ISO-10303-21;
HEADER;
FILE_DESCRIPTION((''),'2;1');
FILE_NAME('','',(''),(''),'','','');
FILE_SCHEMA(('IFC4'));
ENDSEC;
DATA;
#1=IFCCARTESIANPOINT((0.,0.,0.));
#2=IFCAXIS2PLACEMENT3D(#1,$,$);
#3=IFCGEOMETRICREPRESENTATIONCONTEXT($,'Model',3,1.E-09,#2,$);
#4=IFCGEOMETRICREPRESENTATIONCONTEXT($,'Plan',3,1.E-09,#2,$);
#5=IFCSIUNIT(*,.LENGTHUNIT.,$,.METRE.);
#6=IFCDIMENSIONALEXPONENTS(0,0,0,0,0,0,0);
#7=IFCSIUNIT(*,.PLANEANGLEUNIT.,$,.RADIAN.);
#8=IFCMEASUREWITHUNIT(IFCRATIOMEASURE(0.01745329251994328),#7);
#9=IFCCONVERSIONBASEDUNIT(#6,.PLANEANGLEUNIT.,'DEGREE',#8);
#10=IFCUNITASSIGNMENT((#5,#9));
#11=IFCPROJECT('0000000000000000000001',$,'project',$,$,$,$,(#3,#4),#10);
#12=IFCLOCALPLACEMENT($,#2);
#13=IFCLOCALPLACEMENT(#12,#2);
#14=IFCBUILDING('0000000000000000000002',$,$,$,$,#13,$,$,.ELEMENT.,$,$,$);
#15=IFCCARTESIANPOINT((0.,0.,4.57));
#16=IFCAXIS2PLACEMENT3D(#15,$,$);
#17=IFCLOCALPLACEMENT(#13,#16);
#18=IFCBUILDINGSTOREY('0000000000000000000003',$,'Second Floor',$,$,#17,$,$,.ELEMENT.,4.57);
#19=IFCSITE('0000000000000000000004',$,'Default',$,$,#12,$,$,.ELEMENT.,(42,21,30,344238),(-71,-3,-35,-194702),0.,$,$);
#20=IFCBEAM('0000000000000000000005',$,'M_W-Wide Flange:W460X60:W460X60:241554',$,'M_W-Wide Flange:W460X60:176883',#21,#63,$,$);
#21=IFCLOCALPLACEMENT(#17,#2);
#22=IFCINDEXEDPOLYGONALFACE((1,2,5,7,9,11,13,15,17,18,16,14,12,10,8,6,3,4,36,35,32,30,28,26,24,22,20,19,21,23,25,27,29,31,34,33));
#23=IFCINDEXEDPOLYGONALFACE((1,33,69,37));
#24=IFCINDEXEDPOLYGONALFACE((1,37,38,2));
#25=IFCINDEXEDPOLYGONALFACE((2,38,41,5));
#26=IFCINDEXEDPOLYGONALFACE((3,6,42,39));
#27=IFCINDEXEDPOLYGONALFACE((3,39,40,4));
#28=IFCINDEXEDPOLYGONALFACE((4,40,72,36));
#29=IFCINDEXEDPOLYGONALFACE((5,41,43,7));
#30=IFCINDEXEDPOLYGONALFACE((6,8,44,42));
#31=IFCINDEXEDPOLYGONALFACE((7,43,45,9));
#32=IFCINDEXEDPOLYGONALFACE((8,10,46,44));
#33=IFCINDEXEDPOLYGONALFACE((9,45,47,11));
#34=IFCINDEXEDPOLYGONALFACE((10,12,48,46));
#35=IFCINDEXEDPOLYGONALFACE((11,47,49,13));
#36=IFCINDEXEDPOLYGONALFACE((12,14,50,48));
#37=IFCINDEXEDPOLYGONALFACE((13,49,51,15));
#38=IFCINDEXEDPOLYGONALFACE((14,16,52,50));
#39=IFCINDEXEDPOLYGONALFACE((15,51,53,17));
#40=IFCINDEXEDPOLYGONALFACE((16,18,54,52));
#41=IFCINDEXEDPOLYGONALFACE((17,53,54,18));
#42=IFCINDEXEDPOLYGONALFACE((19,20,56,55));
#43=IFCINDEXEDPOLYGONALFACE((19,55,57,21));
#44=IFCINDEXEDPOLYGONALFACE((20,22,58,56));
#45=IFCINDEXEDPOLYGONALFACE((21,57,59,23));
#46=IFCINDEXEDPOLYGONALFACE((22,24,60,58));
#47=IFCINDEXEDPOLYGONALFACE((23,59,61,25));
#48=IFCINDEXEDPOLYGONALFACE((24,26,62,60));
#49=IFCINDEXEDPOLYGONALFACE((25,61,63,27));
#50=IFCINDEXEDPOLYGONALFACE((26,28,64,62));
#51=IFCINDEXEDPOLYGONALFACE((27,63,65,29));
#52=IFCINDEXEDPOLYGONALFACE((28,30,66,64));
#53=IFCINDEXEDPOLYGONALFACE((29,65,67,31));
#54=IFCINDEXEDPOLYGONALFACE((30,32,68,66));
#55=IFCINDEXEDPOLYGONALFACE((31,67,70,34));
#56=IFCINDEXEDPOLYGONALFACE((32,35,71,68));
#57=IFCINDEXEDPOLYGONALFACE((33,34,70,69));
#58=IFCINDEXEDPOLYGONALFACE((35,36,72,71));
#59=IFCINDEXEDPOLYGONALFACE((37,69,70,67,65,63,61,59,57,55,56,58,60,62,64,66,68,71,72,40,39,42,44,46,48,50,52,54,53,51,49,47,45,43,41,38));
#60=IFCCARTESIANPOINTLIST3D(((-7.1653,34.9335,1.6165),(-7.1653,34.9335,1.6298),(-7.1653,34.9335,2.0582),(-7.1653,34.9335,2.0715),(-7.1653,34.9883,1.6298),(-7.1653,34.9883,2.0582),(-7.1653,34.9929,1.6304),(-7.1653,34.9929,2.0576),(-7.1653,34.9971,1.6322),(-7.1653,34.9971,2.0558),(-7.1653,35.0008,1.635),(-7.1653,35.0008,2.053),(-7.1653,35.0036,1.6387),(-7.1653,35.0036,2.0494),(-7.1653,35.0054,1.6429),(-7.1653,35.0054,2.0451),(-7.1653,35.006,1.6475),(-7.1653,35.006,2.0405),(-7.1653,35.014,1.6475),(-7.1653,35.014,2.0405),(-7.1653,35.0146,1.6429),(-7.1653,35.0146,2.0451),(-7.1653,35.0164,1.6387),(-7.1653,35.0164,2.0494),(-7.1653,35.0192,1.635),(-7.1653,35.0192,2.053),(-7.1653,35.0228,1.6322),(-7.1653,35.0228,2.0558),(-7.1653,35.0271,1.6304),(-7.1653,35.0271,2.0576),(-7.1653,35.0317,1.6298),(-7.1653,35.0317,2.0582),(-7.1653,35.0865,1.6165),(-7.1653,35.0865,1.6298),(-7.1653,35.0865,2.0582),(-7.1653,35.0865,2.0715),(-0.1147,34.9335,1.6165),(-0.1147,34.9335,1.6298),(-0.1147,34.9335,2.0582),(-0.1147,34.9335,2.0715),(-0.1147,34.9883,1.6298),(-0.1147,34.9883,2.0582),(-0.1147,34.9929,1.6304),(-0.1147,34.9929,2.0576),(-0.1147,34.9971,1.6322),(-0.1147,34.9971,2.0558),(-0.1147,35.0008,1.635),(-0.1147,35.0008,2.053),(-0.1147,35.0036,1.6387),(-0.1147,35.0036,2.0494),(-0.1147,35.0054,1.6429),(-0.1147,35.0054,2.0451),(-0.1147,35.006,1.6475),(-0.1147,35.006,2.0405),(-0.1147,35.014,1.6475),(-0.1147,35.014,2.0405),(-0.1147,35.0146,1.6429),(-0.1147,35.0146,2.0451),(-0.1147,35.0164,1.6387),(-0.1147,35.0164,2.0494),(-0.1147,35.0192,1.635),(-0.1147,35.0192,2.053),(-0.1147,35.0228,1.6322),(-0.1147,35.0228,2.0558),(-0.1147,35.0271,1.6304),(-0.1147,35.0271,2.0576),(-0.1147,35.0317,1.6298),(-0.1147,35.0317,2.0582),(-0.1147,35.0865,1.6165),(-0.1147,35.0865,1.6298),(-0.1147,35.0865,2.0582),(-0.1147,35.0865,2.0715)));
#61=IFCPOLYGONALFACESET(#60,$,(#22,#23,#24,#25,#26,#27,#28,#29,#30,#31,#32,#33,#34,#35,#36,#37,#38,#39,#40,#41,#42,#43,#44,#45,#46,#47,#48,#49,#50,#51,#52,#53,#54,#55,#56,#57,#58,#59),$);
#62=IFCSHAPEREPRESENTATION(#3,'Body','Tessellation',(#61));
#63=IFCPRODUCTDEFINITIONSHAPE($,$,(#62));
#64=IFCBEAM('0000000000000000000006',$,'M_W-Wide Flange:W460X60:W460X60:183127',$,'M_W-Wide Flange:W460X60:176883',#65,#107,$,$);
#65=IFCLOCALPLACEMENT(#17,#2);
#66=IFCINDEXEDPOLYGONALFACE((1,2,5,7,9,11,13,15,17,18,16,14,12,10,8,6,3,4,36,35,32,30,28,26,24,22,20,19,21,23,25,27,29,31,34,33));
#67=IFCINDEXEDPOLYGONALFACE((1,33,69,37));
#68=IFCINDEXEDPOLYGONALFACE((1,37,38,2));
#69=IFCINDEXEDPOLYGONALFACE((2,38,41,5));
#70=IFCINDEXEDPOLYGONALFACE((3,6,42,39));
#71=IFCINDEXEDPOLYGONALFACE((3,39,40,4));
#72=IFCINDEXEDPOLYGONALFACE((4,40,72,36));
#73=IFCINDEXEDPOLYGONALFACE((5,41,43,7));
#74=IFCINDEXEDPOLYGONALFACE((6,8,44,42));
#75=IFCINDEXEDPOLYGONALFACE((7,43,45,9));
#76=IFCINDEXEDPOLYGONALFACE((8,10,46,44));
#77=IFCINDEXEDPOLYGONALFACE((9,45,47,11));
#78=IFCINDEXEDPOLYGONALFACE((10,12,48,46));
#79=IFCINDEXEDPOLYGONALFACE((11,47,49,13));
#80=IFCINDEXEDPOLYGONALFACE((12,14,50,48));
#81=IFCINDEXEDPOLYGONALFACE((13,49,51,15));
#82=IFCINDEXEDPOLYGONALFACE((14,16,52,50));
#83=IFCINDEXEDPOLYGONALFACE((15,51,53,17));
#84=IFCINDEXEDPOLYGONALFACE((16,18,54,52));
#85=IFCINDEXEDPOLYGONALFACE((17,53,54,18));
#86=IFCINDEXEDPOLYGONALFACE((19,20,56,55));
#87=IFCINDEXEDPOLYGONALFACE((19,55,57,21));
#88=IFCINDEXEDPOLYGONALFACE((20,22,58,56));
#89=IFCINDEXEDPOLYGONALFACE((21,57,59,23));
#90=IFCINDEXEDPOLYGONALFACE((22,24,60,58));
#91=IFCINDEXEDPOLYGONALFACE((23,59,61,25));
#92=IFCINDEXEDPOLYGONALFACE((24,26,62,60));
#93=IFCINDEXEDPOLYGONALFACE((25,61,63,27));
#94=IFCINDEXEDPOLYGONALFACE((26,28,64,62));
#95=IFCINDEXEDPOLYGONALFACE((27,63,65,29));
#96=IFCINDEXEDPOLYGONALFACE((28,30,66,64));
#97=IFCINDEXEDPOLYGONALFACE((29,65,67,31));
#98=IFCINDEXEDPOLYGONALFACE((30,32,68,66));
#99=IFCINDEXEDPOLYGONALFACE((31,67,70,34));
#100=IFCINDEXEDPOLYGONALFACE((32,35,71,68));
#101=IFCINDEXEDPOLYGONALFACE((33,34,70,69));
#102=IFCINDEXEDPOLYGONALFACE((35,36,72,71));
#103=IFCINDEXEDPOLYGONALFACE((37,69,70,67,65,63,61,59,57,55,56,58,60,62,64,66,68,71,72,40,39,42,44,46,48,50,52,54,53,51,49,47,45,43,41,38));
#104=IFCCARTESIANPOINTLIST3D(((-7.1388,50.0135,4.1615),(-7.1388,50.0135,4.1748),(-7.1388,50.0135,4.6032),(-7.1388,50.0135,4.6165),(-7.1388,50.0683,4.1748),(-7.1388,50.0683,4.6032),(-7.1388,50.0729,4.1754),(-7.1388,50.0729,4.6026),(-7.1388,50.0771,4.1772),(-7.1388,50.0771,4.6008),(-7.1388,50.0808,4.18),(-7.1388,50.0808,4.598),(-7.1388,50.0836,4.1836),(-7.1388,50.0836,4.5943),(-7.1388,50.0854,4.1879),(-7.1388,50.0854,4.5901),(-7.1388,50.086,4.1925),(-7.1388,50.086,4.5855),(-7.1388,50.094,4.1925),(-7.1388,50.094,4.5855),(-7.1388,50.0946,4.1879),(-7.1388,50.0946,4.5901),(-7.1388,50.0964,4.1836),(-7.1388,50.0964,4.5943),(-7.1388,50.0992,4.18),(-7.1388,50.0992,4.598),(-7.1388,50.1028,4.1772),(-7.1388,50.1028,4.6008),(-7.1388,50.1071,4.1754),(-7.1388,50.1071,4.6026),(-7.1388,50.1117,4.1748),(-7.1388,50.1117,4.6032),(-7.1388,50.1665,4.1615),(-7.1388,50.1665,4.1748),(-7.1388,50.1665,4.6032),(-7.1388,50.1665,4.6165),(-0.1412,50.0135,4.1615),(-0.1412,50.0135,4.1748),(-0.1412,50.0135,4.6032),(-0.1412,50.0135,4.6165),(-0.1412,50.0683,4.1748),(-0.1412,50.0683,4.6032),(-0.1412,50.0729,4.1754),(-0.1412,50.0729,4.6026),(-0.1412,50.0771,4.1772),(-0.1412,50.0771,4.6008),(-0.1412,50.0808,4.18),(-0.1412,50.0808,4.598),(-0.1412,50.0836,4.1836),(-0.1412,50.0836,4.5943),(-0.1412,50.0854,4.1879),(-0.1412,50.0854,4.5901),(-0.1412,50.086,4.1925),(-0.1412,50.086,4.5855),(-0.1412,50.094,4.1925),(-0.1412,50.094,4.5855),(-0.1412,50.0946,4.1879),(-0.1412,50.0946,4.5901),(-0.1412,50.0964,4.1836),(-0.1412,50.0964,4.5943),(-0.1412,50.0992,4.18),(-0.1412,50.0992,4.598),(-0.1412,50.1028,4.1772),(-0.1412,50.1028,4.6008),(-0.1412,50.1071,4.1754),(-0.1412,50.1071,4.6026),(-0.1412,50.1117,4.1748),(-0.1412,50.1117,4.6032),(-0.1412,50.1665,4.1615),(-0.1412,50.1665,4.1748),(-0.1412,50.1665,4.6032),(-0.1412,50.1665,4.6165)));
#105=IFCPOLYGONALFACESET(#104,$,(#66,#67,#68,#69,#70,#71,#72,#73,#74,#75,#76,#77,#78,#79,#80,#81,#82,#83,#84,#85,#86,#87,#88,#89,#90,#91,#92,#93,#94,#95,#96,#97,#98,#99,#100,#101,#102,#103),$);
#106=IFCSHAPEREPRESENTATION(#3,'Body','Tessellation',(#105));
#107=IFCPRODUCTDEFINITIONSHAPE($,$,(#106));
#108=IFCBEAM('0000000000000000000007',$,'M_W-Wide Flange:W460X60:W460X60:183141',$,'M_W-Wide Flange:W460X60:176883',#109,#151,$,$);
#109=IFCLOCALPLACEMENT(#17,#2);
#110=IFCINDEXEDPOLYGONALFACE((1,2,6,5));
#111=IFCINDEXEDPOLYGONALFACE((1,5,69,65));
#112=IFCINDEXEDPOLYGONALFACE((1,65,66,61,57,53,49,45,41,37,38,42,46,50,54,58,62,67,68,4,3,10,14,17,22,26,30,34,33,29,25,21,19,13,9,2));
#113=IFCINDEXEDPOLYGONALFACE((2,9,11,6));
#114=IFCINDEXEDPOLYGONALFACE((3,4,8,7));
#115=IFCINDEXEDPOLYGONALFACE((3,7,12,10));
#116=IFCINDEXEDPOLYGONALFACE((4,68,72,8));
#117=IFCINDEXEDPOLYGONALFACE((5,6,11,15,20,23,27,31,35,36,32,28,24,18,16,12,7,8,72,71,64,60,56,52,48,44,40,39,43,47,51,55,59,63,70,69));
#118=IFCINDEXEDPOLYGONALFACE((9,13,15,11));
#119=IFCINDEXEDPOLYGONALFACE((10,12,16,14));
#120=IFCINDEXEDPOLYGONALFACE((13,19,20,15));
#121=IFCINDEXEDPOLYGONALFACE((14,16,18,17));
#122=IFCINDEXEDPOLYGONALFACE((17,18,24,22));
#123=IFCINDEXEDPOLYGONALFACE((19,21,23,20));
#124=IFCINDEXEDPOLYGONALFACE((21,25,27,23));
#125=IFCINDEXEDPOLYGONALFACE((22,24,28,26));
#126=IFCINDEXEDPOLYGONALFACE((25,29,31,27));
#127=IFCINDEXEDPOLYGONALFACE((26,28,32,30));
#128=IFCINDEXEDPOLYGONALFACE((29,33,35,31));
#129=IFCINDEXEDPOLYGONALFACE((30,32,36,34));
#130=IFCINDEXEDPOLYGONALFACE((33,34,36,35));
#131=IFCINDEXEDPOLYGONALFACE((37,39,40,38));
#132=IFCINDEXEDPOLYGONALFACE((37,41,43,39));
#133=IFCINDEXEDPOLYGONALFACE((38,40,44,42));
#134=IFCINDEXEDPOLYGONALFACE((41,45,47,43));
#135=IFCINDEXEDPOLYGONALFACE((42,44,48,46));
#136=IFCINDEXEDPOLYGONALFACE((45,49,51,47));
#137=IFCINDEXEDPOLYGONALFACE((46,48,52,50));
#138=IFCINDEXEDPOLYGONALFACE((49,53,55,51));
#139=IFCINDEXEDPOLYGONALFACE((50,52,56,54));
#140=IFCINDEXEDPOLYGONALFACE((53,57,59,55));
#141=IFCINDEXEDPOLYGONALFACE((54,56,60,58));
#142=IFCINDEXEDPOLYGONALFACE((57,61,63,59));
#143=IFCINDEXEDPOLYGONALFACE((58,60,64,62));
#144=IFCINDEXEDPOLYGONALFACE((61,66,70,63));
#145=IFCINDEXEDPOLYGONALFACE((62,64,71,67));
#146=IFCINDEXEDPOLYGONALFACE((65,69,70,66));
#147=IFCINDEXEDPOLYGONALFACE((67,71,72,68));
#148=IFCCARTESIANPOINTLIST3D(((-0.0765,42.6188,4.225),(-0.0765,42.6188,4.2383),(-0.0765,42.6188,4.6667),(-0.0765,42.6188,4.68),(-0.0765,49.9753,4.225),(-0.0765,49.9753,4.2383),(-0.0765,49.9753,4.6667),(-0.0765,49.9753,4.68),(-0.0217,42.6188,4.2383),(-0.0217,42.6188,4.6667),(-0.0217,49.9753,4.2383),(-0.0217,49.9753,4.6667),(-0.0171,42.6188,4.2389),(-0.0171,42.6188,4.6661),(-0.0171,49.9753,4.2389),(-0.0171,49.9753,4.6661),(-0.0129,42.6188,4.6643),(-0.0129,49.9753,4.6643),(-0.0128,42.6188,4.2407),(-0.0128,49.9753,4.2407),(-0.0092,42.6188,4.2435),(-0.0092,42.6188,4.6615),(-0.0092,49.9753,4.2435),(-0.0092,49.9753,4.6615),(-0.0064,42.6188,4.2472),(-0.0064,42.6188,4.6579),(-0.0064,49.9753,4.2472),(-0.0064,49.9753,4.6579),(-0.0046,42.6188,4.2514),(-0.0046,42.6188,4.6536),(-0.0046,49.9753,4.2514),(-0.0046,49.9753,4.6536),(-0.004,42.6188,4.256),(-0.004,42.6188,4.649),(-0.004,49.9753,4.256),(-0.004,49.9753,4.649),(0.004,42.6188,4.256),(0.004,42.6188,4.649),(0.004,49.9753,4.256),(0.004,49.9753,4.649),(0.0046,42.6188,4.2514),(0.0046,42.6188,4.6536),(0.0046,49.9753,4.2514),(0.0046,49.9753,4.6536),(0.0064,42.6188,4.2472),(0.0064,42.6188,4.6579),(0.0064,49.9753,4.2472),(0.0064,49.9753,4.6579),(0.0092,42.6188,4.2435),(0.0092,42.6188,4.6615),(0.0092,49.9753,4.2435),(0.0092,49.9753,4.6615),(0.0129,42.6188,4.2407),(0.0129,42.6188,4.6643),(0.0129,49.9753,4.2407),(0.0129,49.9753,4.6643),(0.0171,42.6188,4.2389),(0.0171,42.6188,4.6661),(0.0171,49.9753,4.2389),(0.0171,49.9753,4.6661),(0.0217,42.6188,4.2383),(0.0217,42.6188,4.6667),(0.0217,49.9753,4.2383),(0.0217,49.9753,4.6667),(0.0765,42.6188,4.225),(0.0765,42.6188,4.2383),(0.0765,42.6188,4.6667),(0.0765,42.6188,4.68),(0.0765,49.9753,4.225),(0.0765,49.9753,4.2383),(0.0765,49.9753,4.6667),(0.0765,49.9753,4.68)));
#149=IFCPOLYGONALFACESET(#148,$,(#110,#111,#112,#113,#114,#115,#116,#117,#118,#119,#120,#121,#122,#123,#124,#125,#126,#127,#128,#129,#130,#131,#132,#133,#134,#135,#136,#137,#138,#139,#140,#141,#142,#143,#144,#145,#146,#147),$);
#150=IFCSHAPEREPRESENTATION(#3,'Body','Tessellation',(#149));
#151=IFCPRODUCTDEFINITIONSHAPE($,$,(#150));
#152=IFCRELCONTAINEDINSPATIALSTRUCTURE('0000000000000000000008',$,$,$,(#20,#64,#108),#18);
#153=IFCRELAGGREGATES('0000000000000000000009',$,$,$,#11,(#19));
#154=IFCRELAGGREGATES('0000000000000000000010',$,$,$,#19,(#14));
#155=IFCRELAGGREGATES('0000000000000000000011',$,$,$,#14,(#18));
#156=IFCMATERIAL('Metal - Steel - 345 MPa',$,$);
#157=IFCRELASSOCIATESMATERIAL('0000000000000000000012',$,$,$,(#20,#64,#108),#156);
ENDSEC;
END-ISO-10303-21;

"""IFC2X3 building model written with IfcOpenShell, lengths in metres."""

from ifc_helpers import new_model, entity, si_unit, converted_unit, frame, frame_2d, origin, place, context, project, spatial, polyline, circle_curve, parameter, trimmed, segment, composite_curve, outline, extrude, material, element, save


model = new_model("IFC2X3")

# Units and contexts
model_context = context("Model", 3, precision=1e-09, world=origin())
plan_context = context("Plan", 3, precision=1e-09, world=origin())
ifc_project = project(units=[si_unit("LENGTHUNIT", "METRE"), converted_unit("PLANEANGLEUNIT", "DEGREE", entity("IfcRatioMeasure", 0.01745329251994328), si_unit("PLANEANGLEUNIT", "RADIAN"), dimensions=[0, 0, 0, 0, 0, 0, 0])], contexts=[model_context, plan_context])

# Site, building, storey
site_placement = place(None, origin())
site = spatial("IfcSite", under=ifc_project, at=site_placement, Name="Default", CompositionType="ELEMENT", RefLatitude=(42, 21, 30, 344238), RefLongitude=(-71, -3, -35, -194702), RefElevation=0.0)
building_placement = place(site_placement, origin())
building = spatial("IfcBuilding", under=site, at=building_placement, CompositionType="ELEMENT")
storey_placement = place(building_placement, frame((0.0, 0.0, 4.57)))
storey = spatial("IfcBuildingStorey", under=building, at=storey_placement, Name="Second Floor", CompositionType="ELEMENT", Elevation=4.57)

# Shared definitions
ifc_material = material(Name="Metal - Steel - 345 MPa")

# Beams
beam_1_placement = place(storey_placement, frame((-7.273, 35.01, 2.0715), z_axis=(0.0, 0.0, 1.0), x_axis=(0.0, -1.0, 0.0)))
element("IfcBeam", 1, at=beam_1_placement, inside=storey, material=ifc_material, Name="M_W-Wide Flange:W460X60:W460X60:241554", ObjectType="M_W-Wide Flange:W460X60:176883", context=model_context, shape_type="SweptSolid", body=[
    extrude(outline(composite_curve([segment(polyline([(-0.0765, -0.2142), (-0.0765, -0.2275)]), True, "CONTINUOUS"), segment(polyline([(-0.0765, -0.2275), (0.0765, -0.2275)]), True, "CONTINUOUS"), segment(polyline([(0.0765, -0.2275), (0.0765, -0.2142)]), True, "CONTINUOUS"), segment(polyline([(0.0765, -0.2142), (0.0217, -0.2142)]), True, "CONTINUOUS"), segment(trimmed(circle_curve(frame_2d((0.0217, -0.1965), x_axis=(1.0, 0.0)), 0.0177), [parameter(180.0)], [parameter(270.0)], True, "PARAMETER"), False, "CONTINUOUS"), segment(polyline([(0.004, -0.1965), (0.004, 0.1965)]), True, "CONTINUOUS"), segment(trimmed(circle_curve(frame_2d((0.0217, 0.1965), x_axis=(1.0, 0.0)), 0.0177), [parameter(90.0)], [parameter(180.0)], True, "PARAMETER"), False, "CONTINUOUS"), segment(polyline([(0.0217, 0.2142), (0.0765, 0.2142)]), True, "CONTINUOUS"), segment(polyline([(0.0765, 0.2142), (0.0765, 0.2275)]), True, "CONTINUOUS"), segment(polyline([(0.0765, 0.2275), (-0.0765, 0.2275)]), True, "CONTINUOUS"), segment(polyline([(-0.0765, 0.2275), (-0.0765, 0.2142)]), True, "CONTINUOUS"), segment(polyline([(-0.0765, 0.2142), (-0.0217, 0.2142)]), True, "CONTINUOUS"), segment(trimmed(circle_curve(frame_2d((-0.0217, 0.1965), x_axis=(1.0, 0.0)), 0.0177), [parameter(360.0)], [parameter(90.0)], True, "PARAMETER"), False, "CONTINUOUS"), segment(polyline([(-0.004, 0.1965), (-0.004, -0.1965)]), True, "CONTINUOUS"), segment(trimmed(circle_curve(frame_2d((-0.0217, -0.1965), x_axis=(1.0, 0.0)), 0.0177), [parameter(270.0)], [parameter(0.0)], True, "PARAMETER"), False, "CONTINUOUS"), segment(polyline([(-0.0217, -0.2142), (-0.0765, -0.2142)]), True, "CONTINUOUS")], self_intersect=False)), frame((0.0, 0.1077, -0.2275), z_axis=(0.0, -1.0, 0.0), x_axis=(1.0, 0.0, 0.0)), (0.0, 0.0, -1.0), 7.0506),
])
beam_2_placement = place(storey_placement, frame((-7.2774, 50.09, 4.6165), z_axis=(0.0, 0.0, 1.0), x_axis=(0.0, -1.0, 0.0)))
element("IfcBeam", 2, at=beam_2_placement, inside=storey, material=ifc_material, Name="M_W-Wide Flange:W460X60:W460X60:183127", ObjectType="M_W-Wide Flange:W460X60:176883", context=model_context, shape_type="SweptSolid", body=[
    extrude(outline(composite_curve([segment(polyline([(-0.0765, -0.2142), (-0.0765, -0.2275)]), True, "CONTINUOUS"), segment(polyline([(-0.0765, -0.2275), (0.0765, -0.2275)]), True, "CONTINUOUS"), segment(polyline([(0.0765, -0.2275), (0.0765, -0.2142)]), True, "CONTINUOUS"), segment(polyline([(0.0765, -0.2142), (0.0217, -0.2142)]), True, "CONTINUOUS"), segment(trimmed(circle_curve(frame_2d((0.0217, -0.1965), x_axis=(0.0, -1.0)), 0.0177), [parameter(270.0)], [parameter(360.0)], True, "PARAMETER"), False, "CONTINUOUS"), segment(polyline([(0.004, -0.1965), (0.004, 0.1965)]), True, "CONTINUOUS"), segment(trimmed(circle_curve(frame_2d((0.0217, 0.1965), x_axis=(-1.0, 0.0)), 0.0177), [parameter(270.0)], [parameter(360.0)], True, "PARAMETER"), False, "CONTINUOUS"), segment(polyline([(0.0217, 0.2142), (0.0765, 0.2142)]), True, "CONTINUOUS"), segment(polyline([(0.0765, 0.2142), (0.0765, 0.2275)]), True, "CONTINUOUS"), segment(polyline([(0.0765, 0.2275), (-0.0765, 0.2275)]), True, "CONTINUOUS"), segment(polyline([(-0.0765, 0.2275), (-0.0765, 0.2142)]), True, "CONTINUOUS"), segment(polyline([(-0.0765, 0.2142), (-0.0217, 0.2142)]), True, "CONTINUOUS"), segment(trimmed(circle_curve(frame_2d((-0.0217, 0.1965), x_axis=(0.0, 1.0)), 0.0177), [parameter(270.0)], [parameter(360.0)], True, "PARAMETER"), False, "CONTINUOUS"), segment(polyline([(-0.004, 0.1965), (-0.004, -0.1965)]), True, "CONTINUOUS"), segment(trimmed(circle_curve(frame_2d((-0.0217, -0.1965), x_axis=(1.0, 0.0)), 0.0177), [parameter(270.0)], [parameter(0.0)], True, "PARAMETER"), False, "CONTINUOUS"), segment(polyline([(-0.0217, -0.2142), (-0.0765, -0.2142)]), True, "CONTINUOUS")], self_intersect=False)), frame((0.0, 0.1386, -0.2275), z_axis=(0.0, -1.0, 0.0), x_axis=(1.0, 0.0, 0.0)), (0.0, 0.0, -1.0), 6.9976),
])
beam_3_placement = place(storey_placement, frame((0.0, 50.0875, 4.68), z_axis=(0.0, 0.0, 1.0), x_axis=(-1.0, 0.0, 0.0)))
element("IfcBeam", 3, at=beam_3_placement, inside=storey, material=ifc_material, Name="M_W-Wide Flange:W460X60:W460X60:183141", ObjectType="M_W-Wide Flange:W460X60:176883", context=model_context, shape_type="SweptSolid", body=[
    extrude(outline(composite_curve([segment(polyline([(0.2142, -0.0765), (0.2275, -0.0765)]), True, "CONTINUOUS"), segment(polyline([(0.2275, -0.0765), (0.2275, 0.0765)]), True, "CONTINUOUS"), segment(polyline([(0.2275, 0.0765), (0.2142, 0.0765)]), True, "CONTINUOUS"), segment(polyline([(0.2142, 0.0765), (0.2142, 0.0217)]), True, "CONTINUOUS"), segment(trimmed(circle_curve(frame_2d((0.1965, 0.0217), x_axis=(1.0, 0.0)), 0.0177), [parameter(270.0)], [parameter(360.0)], True, "PARAMETER"), False, "CONTINUOUS"), segment(polyline([(0.1965, 0.004), (-0.1965, 0.004)]), True, "CONTINUOUS"), segment(trimmed(circle_curve(frame_2d((-0.1965, 0.0217), x_axis=(0.0, -1.0)), 0.0177), [parameter(270.0)], [parameter(360.0)], True, "PARAMETER"), False, "CONTINUOUS"), segment(polyline([(-0.2142, 0.0217), (-0.2142, 0.0765)]), True, "CONTINUOUS"), segment(polyline([(-0.2142, 0.0765), (-0.2275, 0.0765)]), True, "CONTINUOUS"), segment(polyline([(-0.2275, 0.0765), (-0.2275, -0.0765)]), True, "CONTINUOUS"), segment(polyline([(-0.2275, -0.0765), (-0.2142, -0.0765)]), True, "CONTINUOUS"), segment(polyline([(-0.2142, -0.0765), (-0.2142, -0.0217)]), True, "CONTINUOUS"), segment(trimmed(circle_curve(frame_2d((-0.1965, -0.0217), x_axis=(-1.0, 0.0)), 0.0177), [parameter(270.0)], [parameter(360.0)], True, "PARAMETER"), False, "CONTINUOUS"), segment(polyline([(-0.1965, -0.004), (0.1965, -0.004)]), True, "CONTINUOUS"), segment(trimmed(circle_curve(frame_2d((0.1965, -0.0217), x_axis=(0.0, 1.0)), 0.0177), [parameter(270.0)], [parameter(0.0)], True, "PARAMETER"), False, "CONTINUOUS"), segment(polyline([(0.2142, -0.0217), (0.2142, -0.0765)]), True, "CONTINUOUS")], self_intersect=False)), frame((0.0, 7.4687, -0.2275), z_axis=(0.0, -1.0, 0.0), x_axis=(0.0, 0.0, -1.0)), (0.0, 0.0, 1.0), 7.3565),
])

save(model, "model.ifc")
